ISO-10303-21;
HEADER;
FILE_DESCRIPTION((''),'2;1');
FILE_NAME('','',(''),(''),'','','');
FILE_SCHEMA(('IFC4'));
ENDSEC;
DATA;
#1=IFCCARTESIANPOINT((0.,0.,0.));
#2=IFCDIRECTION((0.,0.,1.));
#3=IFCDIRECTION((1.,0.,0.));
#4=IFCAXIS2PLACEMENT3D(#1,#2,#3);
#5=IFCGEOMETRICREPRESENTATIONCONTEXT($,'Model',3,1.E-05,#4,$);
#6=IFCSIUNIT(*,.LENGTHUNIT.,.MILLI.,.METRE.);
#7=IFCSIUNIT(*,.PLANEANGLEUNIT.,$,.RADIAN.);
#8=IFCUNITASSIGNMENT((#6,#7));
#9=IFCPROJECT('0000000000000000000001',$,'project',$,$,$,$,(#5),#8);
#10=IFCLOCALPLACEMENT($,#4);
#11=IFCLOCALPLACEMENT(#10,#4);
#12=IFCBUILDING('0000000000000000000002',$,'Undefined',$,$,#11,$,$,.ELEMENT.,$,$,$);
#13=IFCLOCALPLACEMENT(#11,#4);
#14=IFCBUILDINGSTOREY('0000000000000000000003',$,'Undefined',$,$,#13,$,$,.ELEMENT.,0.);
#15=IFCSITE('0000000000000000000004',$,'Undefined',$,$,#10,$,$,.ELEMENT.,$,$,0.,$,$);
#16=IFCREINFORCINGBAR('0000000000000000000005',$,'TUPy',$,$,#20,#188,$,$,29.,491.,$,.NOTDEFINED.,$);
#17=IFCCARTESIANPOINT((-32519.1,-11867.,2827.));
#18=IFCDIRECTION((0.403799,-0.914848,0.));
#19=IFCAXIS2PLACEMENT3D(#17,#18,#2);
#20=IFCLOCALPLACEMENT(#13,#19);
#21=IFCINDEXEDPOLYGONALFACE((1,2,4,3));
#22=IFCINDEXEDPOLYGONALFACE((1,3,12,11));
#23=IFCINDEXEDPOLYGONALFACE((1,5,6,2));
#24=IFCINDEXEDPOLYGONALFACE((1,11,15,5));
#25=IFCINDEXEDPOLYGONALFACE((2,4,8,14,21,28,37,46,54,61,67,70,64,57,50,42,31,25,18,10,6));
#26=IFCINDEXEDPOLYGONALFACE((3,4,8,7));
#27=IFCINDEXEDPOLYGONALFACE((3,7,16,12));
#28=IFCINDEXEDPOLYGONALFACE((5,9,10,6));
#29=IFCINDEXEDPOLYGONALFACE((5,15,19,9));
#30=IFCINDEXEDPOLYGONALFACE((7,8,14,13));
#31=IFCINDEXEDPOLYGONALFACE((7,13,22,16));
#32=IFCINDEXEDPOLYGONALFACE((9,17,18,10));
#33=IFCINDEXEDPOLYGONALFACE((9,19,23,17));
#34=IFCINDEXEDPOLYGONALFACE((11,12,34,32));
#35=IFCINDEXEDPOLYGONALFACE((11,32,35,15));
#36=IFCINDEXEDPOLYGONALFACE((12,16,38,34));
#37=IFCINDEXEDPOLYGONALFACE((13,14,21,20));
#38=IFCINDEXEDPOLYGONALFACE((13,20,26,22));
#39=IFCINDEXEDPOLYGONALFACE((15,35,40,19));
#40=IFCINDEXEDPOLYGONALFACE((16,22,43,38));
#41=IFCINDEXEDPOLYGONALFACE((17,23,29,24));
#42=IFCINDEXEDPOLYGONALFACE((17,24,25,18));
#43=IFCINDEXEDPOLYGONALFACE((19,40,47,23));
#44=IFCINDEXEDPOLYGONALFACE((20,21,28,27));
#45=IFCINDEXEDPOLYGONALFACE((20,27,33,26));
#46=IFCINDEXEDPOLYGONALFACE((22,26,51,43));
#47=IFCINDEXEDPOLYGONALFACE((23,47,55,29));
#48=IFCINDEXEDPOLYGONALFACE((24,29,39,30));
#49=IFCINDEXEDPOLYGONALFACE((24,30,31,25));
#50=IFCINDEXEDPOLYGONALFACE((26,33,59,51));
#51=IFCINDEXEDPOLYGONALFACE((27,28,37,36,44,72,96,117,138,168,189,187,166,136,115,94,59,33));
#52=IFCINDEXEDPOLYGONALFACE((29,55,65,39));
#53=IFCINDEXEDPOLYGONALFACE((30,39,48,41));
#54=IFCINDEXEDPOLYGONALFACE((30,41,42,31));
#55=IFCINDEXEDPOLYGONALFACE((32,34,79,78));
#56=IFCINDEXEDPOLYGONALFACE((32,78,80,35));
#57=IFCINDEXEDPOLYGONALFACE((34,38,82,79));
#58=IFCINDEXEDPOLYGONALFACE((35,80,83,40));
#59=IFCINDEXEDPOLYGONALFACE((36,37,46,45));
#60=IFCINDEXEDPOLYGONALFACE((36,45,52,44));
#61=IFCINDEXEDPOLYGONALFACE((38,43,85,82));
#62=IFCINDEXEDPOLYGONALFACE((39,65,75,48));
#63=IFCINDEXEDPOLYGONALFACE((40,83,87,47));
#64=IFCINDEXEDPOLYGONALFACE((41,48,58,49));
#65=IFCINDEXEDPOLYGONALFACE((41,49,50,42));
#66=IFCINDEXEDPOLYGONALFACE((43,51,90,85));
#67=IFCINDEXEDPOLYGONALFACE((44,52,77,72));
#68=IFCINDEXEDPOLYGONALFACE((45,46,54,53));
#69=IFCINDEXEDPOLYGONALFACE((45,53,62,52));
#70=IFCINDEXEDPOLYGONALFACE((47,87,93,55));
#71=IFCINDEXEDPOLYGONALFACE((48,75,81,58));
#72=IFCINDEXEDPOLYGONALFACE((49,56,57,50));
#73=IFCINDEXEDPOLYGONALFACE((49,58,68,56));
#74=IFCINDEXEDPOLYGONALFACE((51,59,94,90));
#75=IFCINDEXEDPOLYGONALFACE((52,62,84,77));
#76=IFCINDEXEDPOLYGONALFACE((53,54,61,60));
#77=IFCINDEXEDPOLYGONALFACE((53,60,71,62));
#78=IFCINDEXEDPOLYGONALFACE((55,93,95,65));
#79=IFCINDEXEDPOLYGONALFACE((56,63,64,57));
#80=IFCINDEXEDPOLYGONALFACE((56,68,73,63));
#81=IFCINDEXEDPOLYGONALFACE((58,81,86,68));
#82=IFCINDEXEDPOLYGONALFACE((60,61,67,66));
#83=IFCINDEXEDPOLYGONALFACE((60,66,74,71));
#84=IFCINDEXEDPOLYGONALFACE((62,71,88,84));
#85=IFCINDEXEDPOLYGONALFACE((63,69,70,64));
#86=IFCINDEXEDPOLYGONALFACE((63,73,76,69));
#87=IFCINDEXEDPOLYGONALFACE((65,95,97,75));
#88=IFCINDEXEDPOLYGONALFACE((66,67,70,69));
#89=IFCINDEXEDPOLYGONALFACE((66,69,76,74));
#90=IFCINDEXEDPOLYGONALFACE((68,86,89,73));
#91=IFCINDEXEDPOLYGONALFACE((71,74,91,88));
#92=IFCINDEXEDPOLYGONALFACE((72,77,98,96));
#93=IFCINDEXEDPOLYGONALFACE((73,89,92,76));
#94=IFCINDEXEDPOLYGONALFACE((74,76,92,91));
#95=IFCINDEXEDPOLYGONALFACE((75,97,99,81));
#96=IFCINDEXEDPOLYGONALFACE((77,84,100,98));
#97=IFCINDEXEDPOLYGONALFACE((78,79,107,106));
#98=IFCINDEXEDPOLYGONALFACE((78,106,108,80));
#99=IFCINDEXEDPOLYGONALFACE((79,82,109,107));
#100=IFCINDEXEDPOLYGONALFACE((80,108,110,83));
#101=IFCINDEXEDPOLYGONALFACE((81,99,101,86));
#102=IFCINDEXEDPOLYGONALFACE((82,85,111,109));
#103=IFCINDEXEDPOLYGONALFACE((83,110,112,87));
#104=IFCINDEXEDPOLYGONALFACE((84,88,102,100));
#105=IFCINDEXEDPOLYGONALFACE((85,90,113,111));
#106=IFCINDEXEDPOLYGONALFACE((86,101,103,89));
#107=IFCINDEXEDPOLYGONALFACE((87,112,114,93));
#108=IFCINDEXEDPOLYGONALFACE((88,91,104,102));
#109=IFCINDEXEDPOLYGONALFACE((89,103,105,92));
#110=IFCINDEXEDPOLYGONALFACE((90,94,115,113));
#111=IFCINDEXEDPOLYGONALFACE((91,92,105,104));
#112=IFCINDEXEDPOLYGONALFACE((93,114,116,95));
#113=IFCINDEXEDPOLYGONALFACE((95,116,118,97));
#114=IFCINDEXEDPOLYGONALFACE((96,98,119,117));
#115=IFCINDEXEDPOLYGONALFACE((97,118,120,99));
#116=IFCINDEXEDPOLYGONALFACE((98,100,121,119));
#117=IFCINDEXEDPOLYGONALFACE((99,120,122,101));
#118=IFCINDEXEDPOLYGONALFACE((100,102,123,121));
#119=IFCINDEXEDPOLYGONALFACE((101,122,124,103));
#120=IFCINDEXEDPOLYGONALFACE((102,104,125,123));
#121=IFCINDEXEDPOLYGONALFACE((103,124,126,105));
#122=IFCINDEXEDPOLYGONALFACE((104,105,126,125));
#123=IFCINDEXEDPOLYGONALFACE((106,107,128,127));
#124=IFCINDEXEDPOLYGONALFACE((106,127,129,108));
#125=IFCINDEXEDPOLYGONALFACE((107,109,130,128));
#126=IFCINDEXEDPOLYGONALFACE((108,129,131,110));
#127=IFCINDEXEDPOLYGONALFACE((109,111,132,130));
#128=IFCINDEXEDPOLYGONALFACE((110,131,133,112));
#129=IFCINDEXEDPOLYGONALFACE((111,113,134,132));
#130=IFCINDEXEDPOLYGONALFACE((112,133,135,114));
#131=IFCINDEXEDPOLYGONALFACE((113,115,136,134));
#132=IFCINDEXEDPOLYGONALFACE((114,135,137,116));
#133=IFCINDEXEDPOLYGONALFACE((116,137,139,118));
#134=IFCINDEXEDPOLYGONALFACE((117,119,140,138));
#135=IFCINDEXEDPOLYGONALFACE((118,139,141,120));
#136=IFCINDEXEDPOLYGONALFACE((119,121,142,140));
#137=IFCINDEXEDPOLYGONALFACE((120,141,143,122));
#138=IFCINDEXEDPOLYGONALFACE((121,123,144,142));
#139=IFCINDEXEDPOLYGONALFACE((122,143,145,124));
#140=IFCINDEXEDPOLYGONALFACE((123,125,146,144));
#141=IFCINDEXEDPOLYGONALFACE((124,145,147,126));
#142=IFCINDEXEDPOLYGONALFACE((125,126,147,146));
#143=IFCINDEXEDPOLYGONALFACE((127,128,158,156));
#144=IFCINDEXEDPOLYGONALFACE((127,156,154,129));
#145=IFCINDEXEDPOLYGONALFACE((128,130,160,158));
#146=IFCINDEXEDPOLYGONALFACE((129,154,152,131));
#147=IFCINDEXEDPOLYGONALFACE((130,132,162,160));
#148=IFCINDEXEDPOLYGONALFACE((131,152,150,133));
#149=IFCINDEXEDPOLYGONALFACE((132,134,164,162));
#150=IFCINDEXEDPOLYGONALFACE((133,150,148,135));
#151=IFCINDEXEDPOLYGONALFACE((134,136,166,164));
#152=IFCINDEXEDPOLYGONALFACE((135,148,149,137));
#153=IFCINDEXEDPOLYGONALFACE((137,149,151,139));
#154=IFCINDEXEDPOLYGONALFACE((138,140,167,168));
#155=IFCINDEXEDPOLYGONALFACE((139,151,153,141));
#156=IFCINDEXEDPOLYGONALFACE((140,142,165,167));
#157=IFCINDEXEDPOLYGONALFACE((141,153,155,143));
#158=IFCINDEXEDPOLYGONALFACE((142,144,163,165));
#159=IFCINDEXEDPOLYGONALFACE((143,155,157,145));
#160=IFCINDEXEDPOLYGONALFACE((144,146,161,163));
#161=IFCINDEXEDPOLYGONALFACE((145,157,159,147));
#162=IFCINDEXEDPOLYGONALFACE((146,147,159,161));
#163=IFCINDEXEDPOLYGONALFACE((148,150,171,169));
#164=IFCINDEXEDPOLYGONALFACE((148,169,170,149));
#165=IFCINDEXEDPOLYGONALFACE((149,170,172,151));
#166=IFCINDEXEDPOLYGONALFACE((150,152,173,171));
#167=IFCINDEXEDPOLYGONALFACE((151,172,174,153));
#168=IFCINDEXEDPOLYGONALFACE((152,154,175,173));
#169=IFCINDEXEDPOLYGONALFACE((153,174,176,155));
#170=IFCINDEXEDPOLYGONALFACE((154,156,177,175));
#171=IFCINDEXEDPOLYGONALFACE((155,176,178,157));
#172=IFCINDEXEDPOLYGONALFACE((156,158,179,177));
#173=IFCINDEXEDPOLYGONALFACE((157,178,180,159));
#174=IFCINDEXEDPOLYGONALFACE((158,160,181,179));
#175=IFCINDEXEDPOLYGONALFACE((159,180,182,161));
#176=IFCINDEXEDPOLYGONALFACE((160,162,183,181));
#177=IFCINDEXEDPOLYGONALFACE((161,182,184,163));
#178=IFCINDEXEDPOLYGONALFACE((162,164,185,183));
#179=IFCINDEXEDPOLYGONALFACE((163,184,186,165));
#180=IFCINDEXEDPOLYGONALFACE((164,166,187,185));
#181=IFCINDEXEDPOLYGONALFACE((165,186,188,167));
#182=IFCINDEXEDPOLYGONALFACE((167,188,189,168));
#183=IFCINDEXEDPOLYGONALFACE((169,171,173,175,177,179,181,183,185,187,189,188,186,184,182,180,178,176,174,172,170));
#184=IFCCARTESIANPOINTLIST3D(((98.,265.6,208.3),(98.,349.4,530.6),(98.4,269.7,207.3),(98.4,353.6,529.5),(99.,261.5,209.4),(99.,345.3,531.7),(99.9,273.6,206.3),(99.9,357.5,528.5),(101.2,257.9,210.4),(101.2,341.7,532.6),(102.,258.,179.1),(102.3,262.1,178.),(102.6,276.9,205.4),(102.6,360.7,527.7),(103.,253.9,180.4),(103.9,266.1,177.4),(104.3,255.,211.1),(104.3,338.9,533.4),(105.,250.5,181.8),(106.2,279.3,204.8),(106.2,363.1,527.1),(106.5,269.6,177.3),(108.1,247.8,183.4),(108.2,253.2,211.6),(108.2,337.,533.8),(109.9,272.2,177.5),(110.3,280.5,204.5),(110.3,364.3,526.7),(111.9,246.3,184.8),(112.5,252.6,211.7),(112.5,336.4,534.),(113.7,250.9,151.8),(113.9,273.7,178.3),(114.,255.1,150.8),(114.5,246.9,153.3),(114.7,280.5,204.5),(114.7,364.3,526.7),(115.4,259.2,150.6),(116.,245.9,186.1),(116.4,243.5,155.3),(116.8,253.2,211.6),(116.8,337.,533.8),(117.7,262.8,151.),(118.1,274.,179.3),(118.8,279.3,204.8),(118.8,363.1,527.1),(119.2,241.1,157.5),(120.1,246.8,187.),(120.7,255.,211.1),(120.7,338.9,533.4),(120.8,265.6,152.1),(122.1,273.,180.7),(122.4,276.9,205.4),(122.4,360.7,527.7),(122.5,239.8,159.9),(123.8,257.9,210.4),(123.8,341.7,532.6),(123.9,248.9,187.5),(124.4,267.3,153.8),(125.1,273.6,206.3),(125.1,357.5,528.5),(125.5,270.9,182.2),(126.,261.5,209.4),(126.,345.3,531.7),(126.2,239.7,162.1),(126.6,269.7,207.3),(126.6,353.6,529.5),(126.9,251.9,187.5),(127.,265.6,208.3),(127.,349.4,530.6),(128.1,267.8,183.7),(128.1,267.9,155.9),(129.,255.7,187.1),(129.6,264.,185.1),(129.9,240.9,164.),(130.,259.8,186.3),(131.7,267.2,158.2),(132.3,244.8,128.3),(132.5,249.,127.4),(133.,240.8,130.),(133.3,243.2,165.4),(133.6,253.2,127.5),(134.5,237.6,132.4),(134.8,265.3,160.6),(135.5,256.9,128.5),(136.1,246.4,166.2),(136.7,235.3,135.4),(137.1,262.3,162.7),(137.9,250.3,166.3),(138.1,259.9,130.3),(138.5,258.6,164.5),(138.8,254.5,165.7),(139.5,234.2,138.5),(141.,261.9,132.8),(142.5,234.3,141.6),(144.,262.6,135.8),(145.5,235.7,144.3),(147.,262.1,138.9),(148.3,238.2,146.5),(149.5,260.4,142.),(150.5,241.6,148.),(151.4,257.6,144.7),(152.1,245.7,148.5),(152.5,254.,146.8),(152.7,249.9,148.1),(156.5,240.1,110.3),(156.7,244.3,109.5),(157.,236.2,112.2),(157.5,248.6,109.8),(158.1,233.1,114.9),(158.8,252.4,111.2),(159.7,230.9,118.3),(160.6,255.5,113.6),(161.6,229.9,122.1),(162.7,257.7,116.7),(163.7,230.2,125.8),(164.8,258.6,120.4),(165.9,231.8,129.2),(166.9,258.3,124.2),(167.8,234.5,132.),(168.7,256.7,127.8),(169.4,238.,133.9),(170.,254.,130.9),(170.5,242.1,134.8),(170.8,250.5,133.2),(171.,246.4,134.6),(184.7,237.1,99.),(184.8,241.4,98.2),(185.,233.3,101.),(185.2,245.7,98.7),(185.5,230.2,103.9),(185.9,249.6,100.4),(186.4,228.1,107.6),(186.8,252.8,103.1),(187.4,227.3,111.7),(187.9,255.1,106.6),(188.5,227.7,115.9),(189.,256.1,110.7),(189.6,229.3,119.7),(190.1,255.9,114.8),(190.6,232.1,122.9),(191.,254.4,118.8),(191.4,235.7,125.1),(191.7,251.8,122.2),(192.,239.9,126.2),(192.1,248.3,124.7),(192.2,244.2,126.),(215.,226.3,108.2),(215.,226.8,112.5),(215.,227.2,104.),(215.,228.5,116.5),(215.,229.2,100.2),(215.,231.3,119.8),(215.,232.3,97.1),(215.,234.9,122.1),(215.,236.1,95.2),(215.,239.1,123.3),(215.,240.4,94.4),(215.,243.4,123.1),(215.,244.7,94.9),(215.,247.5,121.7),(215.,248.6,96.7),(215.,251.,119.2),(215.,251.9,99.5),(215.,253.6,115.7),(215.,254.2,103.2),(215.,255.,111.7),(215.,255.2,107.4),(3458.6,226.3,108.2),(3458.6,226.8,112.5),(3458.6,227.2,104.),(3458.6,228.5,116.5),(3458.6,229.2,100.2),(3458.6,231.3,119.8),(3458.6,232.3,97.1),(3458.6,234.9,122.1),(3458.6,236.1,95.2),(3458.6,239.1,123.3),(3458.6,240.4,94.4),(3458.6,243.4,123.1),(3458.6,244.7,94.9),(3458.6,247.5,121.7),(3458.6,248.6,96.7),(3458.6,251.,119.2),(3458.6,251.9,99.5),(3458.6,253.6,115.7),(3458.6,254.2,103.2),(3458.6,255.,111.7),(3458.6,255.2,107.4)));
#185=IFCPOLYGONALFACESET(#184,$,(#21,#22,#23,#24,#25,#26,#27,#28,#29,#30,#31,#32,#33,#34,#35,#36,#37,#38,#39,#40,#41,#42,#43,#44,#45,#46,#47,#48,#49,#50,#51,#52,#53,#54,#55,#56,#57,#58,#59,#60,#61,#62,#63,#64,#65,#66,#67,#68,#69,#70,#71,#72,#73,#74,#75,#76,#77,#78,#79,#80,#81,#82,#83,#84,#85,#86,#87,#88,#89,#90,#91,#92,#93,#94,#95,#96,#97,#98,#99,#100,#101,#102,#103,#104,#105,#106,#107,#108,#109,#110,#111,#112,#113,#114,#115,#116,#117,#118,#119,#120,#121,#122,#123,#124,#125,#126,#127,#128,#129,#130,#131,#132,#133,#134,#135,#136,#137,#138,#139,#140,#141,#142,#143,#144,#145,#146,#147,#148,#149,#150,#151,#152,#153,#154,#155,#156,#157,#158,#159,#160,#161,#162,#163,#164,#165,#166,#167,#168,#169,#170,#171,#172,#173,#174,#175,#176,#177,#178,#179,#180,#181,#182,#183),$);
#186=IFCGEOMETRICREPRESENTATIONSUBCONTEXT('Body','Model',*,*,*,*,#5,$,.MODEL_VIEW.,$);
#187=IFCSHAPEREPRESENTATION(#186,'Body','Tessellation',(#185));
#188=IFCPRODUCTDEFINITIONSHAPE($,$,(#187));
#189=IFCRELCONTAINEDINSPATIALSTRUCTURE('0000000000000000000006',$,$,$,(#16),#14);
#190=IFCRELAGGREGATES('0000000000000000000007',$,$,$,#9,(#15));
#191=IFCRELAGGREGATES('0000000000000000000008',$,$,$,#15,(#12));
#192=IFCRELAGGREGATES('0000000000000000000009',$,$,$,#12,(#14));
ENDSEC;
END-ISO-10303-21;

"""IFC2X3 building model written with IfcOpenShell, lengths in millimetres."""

from ifc_helpers import new_model, entity, si_unit, frame, origin_with_axes, place, context, subcontext, project, spatial, source, transform, mapped, element, save


model = new_model("IFC2X3")

# Units and contexts
model_context = context("Model", 3, precision=1e-05, world=origin_with_axes())
body_context = subcontext(model_context, "Body", "Model", "MODEL_VIEW")
ifc_project = project(units=[si_unit("LENGTHUNIT", "METRE", prefix="MILLI"), si_unit("PLANEANGLEUNIT", "RADIAN")], contexts=[model_context])

# Site, building, storey
site_placement = place(None, origin_with_axes())
site = spatial("IfcSite", under=ifc_project, at=site_placement, Name="Undefined", CompositionType="ELEMENT", RefElevation=0.0)
building_placement = place(site_placement, origin_with_axes())
building = spatial("IfcBuilding", under=site, at=building_placement, Name="Undefined", CompositionType="ELEMENT")
storey_placement = place(building_placement, origin_with_axes())
storey = spatial("IfcBuildingStorey", under=building, at=storey_placement, Name="Undefined", CompositionType="ELEMENT", Elevation=0.0)

# Reinforcing bar
shared_shape_1 = source(origin_with_axes(), body_context, "Body", "AdvancedSweptSolid", [
    entity("IfcSweptDiskSolid", entity("IfcCompositeCurve", [entity("IfcCompositeCurveSegment", "CONTINUOUS", True, entity("IfcTrimmedCurve", entity("IfcLine", entity("IfcCartesianPoint", [0.0, 0.0, 0.0]), entity("IfcVector", entity("IfcDirection", [0.0, -0.25174, -0.967795]), 1.0)), [entity("IfcParameterValue", 0.0)], [entity("IfcParameterValue", 333.0)], True, "PARAMETER")), entity("IfcCompositeCurveSegment", "CONTINUOUS", True, entity("IfcTrimmedCurve", entity("IfcCircle", entity("IfcAxis2Placement3D", entity("IfcCartesianPoint", [102.5, -83.8, -322.3]), entity("IfcDirection", [0.0, -0.967795, 0.25174]), entity("IfcDirection", [-1.0, 0.0, 0.0])), 102.5), [entity("IfcParameterValue", 0.0)], [entity("IfcParameterValue", 1.570796)], True, "PARAMETER")), entity("IfcCompositeCurveSegment", "DISCONTINUOUS", True, entity("IfcTrimmedCurve", entity("IfcLine", entity("IfcCartesianPoint", [102.5, -109.6, -421.5]), entity("IfcVector", entity("IfcDirection", [1.0, 0.0, 0.0]), 1.0)), [entity("IfcParameterValue", 0.0)], [entity("IfcParameterValue", 3243.607639)], True, "PARAMETER"))], False), 14.5, None, 0.0, 3578.2),
])
reinforcing_bar_1_placement = place(storey_placement, frame((-32519.1, -11867.0, 2827.0), z_axis=(0.403799, -0.914848, 0.0), x_axis=(0.0, 0.0, 1.0)))
element("IfcReinforcingBar", 1, at=reinforcing_bar_1_placement, inside=storey, Name="TUPy", BarRole="NOTDEFINED", CrossSectionArea=491.0, NominalDiameter=29.0, context=body_context, shape_type="MappedRepresentation", body=[
    mapped(shared_shape_1, transform((112.5, 350.5, 530.4))),
])

save(model, "model.ifc")
